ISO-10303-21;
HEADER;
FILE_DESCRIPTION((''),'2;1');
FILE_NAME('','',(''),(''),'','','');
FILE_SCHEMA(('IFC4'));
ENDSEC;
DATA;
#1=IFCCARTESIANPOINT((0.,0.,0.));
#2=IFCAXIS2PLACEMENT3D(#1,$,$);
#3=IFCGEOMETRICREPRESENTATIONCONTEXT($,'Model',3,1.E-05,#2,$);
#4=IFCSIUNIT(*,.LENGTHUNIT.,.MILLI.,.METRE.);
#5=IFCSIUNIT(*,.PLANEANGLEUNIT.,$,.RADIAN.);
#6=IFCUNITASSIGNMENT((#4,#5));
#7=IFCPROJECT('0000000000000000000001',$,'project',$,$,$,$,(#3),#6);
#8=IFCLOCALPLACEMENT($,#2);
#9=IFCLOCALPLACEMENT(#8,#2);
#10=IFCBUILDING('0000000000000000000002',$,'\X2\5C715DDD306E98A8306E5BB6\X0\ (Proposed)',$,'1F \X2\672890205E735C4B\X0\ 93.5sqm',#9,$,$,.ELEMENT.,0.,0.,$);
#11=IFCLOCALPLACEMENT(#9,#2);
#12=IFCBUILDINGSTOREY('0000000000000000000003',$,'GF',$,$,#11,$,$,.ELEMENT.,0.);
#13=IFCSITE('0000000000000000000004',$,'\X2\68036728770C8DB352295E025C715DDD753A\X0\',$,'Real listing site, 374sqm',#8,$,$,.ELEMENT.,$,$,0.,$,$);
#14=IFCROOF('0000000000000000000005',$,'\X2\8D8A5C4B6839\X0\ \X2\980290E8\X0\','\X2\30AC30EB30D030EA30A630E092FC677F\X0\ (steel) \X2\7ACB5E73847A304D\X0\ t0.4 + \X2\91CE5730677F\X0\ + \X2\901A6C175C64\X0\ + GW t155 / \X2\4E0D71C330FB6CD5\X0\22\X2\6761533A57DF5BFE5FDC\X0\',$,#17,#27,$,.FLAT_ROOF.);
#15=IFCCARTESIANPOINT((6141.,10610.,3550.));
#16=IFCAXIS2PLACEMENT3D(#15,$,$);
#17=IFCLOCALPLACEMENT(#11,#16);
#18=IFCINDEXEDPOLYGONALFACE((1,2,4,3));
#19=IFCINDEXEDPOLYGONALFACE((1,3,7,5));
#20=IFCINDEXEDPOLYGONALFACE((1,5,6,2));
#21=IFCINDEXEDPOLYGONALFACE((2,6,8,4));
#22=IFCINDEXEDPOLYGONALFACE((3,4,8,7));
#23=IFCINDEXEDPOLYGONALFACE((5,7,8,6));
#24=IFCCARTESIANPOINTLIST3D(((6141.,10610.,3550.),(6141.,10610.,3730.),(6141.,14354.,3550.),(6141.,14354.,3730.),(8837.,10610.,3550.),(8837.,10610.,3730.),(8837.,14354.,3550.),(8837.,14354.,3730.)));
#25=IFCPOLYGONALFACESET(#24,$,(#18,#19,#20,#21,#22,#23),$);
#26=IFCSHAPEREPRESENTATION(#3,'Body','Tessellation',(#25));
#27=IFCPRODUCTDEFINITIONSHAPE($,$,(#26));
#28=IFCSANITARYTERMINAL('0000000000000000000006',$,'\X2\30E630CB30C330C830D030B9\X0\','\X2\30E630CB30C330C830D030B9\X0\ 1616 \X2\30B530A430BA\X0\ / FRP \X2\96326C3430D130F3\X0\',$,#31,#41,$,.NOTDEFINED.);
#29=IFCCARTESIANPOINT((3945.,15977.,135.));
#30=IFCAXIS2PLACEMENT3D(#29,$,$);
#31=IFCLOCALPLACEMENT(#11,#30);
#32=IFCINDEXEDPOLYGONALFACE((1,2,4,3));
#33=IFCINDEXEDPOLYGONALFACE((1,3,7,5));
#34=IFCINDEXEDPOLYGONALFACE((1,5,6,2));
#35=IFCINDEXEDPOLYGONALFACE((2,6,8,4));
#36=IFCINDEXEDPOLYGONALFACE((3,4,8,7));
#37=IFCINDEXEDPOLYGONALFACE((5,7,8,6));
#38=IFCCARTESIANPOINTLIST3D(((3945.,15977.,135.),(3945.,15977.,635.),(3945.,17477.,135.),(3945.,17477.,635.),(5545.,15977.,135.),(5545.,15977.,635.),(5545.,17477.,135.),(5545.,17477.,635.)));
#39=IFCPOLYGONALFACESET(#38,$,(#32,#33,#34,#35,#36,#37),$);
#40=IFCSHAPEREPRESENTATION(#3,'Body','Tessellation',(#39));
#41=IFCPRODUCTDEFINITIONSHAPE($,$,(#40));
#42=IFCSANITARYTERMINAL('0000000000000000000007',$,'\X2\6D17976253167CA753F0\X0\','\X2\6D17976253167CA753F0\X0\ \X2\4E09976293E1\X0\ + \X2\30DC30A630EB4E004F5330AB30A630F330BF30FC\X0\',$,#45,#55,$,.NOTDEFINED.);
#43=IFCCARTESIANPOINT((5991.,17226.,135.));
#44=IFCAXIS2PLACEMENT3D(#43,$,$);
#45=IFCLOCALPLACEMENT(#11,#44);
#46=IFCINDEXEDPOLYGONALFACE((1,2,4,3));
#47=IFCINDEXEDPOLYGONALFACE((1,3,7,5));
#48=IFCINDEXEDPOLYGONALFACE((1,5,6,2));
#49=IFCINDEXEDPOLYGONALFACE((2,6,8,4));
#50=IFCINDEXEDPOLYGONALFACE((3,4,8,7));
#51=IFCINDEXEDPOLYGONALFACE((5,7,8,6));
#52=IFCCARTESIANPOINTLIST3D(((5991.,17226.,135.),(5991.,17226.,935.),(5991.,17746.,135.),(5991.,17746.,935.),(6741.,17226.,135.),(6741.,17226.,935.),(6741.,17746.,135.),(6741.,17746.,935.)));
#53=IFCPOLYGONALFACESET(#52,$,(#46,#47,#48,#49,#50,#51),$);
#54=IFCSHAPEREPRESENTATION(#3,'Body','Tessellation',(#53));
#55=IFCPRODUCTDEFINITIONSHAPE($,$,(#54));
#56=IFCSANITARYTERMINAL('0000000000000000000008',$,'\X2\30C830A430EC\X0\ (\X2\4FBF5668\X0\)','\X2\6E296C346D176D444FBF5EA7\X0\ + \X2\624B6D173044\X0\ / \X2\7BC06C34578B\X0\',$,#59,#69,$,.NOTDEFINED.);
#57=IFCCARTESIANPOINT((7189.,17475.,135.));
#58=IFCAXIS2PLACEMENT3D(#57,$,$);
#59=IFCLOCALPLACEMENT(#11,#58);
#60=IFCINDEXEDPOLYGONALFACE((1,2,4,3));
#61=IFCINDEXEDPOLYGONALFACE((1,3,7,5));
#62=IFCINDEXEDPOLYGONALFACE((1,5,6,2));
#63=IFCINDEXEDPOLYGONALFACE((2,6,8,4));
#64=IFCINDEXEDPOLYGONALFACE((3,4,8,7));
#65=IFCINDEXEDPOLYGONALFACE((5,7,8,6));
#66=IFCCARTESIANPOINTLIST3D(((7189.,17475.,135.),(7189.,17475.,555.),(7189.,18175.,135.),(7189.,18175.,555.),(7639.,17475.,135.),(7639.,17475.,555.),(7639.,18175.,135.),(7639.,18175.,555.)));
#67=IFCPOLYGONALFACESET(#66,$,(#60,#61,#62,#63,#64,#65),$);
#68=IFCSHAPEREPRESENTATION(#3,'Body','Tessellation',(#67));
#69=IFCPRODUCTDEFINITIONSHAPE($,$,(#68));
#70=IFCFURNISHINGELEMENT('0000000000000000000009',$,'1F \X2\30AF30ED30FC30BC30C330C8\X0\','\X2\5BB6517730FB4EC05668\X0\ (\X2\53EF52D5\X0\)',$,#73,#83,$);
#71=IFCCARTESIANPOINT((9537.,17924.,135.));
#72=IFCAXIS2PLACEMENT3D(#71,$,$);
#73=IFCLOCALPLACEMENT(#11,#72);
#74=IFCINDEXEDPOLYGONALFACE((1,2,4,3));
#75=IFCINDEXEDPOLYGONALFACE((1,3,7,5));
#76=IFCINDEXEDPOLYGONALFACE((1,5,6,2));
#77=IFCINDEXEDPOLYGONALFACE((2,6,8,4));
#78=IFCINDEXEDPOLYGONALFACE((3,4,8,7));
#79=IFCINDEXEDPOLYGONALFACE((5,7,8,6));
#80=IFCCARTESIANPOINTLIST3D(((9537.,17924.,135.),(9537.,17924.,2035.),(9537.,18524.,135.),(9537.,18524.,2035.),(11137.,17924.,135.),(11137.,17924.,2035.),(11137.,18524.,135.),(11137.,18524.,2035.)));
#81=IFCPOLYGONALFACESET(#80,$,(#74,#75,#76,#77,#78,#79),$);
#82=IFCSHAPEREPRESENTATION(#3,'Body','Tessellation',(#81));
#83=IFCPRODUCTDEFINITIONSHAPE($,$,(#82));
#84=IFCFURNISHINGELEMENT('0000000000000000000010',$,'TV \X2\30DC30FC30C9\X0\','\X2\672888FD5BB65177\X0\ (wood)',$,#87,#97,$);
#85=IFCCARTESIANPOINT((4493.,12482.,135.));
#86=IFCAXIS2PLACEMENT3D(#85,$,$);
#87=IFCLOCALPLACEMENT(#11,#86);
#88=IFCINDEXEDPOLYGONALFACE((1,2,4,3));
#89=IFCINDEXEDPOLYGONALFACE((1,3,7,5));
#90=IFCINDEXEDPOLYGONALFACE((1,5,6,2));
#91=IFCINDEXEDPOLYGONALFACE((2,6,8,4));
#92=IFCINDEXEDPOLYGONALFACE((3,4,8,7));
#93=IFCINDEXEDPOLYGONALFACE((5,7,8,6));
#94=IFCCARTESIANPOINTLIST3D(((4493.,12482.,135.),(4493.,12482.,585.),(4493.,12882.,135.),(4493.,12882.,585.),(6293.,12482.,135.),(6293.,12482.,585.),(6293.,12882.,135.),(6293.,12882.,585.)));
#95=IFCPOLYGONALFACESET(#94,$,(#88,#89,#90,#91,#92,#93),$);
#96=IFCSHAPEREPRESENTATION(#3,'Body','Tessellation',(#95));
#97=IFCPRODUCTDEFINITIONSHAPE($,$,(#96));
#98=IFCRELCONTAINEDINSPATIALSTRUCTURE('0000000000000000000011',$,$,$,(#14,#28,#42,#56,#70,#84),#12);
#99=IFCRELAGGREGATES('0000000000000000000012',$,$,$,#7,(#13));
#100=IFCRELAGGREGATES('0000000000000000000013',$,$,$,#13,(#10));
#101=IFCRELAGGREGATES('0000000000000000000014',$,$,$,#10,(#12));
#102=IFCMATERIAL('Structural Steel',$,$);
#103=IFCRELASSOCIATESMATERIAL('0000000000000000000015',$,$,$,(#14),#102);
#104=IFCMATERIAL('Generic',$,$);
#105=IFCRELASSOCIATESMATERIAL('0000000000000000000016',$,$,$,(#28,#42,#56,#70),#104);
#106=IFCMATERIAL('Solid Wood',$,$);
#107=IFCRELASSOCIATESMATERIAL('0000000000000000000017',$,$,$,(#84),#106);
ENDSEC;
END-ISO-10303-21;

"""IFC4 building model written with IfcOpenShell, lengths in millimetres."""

from ifc_helpers import new_model, si_unit, frame, frame_2d, origin, place, context, project, spatial, rectangle, extrude, material, element, save


model = new_model("IFC4")

# Units and contexts
model_context = context("Model", 3, precision=1e-05, world=origin())
ifc_project = project(units=[si_unit("LENGTHUNIT", "METRE", prefix="MILLI"), si_unit("PLANEANGLEUNIT", "RADIAN")], contexts=[model_context])

# Site, building, storey
site_placement = place(None, origin())
site = spatial("IfcSite", under=ifc_project, at=site_placement, Name="栃木県足利市山川町", ObjectType="Real listing site, 374sqm", CompositionType="ELEMENT", RefElevation=0.0)
building_placement = place(site_placement, origin())
building = spatial("IfcBuilding", under=site, at=building_placement, Name="山川の風の家 (Proposed)", ObjectType="1F 木造平屋 93.5sqm", CompositionType="ELEMENT", ElevationOfRefHeight=0.0, ElevationOfTerrain=0.0)
storey_placement = place(building_placement, origin())
storey = spatial("IfcBuildingStorey", under=building, at=storey_placement, Name="GF", CompositionType="ELEMENT", Elevation=0.0)

# Shared definitions
ifc_material_1 = material(Name="Solid Wood")

# Roof
ifc_material_2 = material(Name="Structural Steel")
roof_placement = place(storey_placement, frame((6141.0, 10610.0, 3550.0)))
element("IfcRoof", 1, at=roof_placement, inside=storey, material=ifc_material_2, Name="越屋根 頂部", Description="ガルバリウム鋼板 (steel) 立平葺き t0.4 + 野地板 + 通気層 + GW t155 / 不燃・法22条区域対応", PredefinedType="FLAT_ROOF", context=model_context, shape_type="SweptSolid", body=[
    extrude(rectangle(XDim=2696.0, YDim=3744.0, at=frame_2d((1348.0, 1872.0))), frame((6141.0, 10610.0, 3550.0)), (0.0, 0.0, 1.0), 180.0),
])

# Sanitary terminals
ifc_material_3 = material(Name="Generic")
sanitary_terminal_1_placement = place(storey_placement, frame((3945.0, 15977.0, 135.0)))
element("IfcSanitaryTerminal", 2, at=sanitary_terminal_1_placement, inside=storey, material=ifc_material_3, Name="ユニットバス", Description="ユニットバス 1616 サイズ / FRP 防水パン", PredefinedType="NOTDEFINED", context=model_context, shape_type="SweptSolid", body=[
    extrude(rectangle(XDim=1600.0, YDim=1500.0, at=frame_2d((800.0, 750.0))), frame((3945.0, 15977.0, 135.0)), (0.0, 0.0, 1.0), 500.0),
])
sanitary_terminal_2_placement = place(storey_placement, frame((5991.0, 17226.0, 135.0)))
element("IfcSanitaryTerminal", 3, at=sanitary_terminal_2_placement, inside=storey, material=ifc_material_3, Name="洗面化粧台", Description="洗面化粧台 三面鏡 + ボウル一体カウンター", PredefinedType="NOTDEFINED", context=model_context, shape_type="SweptSolid", body=[
    extrude(rectangle(XDim=750.0, YDim=520.0, at=frame_2d((375.0, 260.0))), frame((5991.0, 17226.0, 135.0)), (0.0, 0.0, 1.0), 800.0),
])
sanitary_terminal_3_placement = place(storey_placement, frame((7189.0, 17475.0, 135.0)))
element("IfcSanitaryTerminal", 4, at=sanitary_terminal_3_placement, inside=storey, material=ifc_material_3, Name="トイレ (便器)", Description="温水洗浄便座 + 手洗い / 節水型", PredefinedType="NOTDEFINED", context=model_context, shape_type="SweptSolid", body=[
    extrude(rectangle(XDim=450.0, YDim=700.0, at=frame_2d((225.0, 350.0))), frame((7189.0, 17475.0, 135.0)), (0.0, 0.0, 1.0), 420.0),
])

# Furnishing elements
furnishing_1_placement = place(storey_placement, frame((9537.0, 17924.0, 135.0)))
element("IfcFurnishingElement", 5, at=furnishing_1_placement, inside=storey, material=ifc_material_3, Name="1F クローゼット", Description="家具・什器 (可動)", context=model_context, shape_type="SweptSolid", body=[
    extrude(rectangle(XDim=1600.0, YDim=600.0, at=frame_2d((800.0, 300.0))), frame((9537.0, 17924.0, 135.0)), (0.0, 0.0, 1.0), 1900.0),
])
furnishing_2_placement = place(storey_placement, frame((4493.0, 12482.0, 135.0)))
element("IfcFurnishingElement", 6, at=furnishing_2_placement, inside=storey, material=ifc_material_1, Name="TV ボード", Description="木製家具 (wood)", context=model_context, shape_type="SweptSolid", body=[
    extrude(rectangle(XDim=1800.0, YDim=400.0, at=frame_2d((900.0, 200.0))), frame((4493.0, 12482.0, 135.0)), (0.0, 0.0, 1.0), 450.0),
])

save(model, "model.ifc")
